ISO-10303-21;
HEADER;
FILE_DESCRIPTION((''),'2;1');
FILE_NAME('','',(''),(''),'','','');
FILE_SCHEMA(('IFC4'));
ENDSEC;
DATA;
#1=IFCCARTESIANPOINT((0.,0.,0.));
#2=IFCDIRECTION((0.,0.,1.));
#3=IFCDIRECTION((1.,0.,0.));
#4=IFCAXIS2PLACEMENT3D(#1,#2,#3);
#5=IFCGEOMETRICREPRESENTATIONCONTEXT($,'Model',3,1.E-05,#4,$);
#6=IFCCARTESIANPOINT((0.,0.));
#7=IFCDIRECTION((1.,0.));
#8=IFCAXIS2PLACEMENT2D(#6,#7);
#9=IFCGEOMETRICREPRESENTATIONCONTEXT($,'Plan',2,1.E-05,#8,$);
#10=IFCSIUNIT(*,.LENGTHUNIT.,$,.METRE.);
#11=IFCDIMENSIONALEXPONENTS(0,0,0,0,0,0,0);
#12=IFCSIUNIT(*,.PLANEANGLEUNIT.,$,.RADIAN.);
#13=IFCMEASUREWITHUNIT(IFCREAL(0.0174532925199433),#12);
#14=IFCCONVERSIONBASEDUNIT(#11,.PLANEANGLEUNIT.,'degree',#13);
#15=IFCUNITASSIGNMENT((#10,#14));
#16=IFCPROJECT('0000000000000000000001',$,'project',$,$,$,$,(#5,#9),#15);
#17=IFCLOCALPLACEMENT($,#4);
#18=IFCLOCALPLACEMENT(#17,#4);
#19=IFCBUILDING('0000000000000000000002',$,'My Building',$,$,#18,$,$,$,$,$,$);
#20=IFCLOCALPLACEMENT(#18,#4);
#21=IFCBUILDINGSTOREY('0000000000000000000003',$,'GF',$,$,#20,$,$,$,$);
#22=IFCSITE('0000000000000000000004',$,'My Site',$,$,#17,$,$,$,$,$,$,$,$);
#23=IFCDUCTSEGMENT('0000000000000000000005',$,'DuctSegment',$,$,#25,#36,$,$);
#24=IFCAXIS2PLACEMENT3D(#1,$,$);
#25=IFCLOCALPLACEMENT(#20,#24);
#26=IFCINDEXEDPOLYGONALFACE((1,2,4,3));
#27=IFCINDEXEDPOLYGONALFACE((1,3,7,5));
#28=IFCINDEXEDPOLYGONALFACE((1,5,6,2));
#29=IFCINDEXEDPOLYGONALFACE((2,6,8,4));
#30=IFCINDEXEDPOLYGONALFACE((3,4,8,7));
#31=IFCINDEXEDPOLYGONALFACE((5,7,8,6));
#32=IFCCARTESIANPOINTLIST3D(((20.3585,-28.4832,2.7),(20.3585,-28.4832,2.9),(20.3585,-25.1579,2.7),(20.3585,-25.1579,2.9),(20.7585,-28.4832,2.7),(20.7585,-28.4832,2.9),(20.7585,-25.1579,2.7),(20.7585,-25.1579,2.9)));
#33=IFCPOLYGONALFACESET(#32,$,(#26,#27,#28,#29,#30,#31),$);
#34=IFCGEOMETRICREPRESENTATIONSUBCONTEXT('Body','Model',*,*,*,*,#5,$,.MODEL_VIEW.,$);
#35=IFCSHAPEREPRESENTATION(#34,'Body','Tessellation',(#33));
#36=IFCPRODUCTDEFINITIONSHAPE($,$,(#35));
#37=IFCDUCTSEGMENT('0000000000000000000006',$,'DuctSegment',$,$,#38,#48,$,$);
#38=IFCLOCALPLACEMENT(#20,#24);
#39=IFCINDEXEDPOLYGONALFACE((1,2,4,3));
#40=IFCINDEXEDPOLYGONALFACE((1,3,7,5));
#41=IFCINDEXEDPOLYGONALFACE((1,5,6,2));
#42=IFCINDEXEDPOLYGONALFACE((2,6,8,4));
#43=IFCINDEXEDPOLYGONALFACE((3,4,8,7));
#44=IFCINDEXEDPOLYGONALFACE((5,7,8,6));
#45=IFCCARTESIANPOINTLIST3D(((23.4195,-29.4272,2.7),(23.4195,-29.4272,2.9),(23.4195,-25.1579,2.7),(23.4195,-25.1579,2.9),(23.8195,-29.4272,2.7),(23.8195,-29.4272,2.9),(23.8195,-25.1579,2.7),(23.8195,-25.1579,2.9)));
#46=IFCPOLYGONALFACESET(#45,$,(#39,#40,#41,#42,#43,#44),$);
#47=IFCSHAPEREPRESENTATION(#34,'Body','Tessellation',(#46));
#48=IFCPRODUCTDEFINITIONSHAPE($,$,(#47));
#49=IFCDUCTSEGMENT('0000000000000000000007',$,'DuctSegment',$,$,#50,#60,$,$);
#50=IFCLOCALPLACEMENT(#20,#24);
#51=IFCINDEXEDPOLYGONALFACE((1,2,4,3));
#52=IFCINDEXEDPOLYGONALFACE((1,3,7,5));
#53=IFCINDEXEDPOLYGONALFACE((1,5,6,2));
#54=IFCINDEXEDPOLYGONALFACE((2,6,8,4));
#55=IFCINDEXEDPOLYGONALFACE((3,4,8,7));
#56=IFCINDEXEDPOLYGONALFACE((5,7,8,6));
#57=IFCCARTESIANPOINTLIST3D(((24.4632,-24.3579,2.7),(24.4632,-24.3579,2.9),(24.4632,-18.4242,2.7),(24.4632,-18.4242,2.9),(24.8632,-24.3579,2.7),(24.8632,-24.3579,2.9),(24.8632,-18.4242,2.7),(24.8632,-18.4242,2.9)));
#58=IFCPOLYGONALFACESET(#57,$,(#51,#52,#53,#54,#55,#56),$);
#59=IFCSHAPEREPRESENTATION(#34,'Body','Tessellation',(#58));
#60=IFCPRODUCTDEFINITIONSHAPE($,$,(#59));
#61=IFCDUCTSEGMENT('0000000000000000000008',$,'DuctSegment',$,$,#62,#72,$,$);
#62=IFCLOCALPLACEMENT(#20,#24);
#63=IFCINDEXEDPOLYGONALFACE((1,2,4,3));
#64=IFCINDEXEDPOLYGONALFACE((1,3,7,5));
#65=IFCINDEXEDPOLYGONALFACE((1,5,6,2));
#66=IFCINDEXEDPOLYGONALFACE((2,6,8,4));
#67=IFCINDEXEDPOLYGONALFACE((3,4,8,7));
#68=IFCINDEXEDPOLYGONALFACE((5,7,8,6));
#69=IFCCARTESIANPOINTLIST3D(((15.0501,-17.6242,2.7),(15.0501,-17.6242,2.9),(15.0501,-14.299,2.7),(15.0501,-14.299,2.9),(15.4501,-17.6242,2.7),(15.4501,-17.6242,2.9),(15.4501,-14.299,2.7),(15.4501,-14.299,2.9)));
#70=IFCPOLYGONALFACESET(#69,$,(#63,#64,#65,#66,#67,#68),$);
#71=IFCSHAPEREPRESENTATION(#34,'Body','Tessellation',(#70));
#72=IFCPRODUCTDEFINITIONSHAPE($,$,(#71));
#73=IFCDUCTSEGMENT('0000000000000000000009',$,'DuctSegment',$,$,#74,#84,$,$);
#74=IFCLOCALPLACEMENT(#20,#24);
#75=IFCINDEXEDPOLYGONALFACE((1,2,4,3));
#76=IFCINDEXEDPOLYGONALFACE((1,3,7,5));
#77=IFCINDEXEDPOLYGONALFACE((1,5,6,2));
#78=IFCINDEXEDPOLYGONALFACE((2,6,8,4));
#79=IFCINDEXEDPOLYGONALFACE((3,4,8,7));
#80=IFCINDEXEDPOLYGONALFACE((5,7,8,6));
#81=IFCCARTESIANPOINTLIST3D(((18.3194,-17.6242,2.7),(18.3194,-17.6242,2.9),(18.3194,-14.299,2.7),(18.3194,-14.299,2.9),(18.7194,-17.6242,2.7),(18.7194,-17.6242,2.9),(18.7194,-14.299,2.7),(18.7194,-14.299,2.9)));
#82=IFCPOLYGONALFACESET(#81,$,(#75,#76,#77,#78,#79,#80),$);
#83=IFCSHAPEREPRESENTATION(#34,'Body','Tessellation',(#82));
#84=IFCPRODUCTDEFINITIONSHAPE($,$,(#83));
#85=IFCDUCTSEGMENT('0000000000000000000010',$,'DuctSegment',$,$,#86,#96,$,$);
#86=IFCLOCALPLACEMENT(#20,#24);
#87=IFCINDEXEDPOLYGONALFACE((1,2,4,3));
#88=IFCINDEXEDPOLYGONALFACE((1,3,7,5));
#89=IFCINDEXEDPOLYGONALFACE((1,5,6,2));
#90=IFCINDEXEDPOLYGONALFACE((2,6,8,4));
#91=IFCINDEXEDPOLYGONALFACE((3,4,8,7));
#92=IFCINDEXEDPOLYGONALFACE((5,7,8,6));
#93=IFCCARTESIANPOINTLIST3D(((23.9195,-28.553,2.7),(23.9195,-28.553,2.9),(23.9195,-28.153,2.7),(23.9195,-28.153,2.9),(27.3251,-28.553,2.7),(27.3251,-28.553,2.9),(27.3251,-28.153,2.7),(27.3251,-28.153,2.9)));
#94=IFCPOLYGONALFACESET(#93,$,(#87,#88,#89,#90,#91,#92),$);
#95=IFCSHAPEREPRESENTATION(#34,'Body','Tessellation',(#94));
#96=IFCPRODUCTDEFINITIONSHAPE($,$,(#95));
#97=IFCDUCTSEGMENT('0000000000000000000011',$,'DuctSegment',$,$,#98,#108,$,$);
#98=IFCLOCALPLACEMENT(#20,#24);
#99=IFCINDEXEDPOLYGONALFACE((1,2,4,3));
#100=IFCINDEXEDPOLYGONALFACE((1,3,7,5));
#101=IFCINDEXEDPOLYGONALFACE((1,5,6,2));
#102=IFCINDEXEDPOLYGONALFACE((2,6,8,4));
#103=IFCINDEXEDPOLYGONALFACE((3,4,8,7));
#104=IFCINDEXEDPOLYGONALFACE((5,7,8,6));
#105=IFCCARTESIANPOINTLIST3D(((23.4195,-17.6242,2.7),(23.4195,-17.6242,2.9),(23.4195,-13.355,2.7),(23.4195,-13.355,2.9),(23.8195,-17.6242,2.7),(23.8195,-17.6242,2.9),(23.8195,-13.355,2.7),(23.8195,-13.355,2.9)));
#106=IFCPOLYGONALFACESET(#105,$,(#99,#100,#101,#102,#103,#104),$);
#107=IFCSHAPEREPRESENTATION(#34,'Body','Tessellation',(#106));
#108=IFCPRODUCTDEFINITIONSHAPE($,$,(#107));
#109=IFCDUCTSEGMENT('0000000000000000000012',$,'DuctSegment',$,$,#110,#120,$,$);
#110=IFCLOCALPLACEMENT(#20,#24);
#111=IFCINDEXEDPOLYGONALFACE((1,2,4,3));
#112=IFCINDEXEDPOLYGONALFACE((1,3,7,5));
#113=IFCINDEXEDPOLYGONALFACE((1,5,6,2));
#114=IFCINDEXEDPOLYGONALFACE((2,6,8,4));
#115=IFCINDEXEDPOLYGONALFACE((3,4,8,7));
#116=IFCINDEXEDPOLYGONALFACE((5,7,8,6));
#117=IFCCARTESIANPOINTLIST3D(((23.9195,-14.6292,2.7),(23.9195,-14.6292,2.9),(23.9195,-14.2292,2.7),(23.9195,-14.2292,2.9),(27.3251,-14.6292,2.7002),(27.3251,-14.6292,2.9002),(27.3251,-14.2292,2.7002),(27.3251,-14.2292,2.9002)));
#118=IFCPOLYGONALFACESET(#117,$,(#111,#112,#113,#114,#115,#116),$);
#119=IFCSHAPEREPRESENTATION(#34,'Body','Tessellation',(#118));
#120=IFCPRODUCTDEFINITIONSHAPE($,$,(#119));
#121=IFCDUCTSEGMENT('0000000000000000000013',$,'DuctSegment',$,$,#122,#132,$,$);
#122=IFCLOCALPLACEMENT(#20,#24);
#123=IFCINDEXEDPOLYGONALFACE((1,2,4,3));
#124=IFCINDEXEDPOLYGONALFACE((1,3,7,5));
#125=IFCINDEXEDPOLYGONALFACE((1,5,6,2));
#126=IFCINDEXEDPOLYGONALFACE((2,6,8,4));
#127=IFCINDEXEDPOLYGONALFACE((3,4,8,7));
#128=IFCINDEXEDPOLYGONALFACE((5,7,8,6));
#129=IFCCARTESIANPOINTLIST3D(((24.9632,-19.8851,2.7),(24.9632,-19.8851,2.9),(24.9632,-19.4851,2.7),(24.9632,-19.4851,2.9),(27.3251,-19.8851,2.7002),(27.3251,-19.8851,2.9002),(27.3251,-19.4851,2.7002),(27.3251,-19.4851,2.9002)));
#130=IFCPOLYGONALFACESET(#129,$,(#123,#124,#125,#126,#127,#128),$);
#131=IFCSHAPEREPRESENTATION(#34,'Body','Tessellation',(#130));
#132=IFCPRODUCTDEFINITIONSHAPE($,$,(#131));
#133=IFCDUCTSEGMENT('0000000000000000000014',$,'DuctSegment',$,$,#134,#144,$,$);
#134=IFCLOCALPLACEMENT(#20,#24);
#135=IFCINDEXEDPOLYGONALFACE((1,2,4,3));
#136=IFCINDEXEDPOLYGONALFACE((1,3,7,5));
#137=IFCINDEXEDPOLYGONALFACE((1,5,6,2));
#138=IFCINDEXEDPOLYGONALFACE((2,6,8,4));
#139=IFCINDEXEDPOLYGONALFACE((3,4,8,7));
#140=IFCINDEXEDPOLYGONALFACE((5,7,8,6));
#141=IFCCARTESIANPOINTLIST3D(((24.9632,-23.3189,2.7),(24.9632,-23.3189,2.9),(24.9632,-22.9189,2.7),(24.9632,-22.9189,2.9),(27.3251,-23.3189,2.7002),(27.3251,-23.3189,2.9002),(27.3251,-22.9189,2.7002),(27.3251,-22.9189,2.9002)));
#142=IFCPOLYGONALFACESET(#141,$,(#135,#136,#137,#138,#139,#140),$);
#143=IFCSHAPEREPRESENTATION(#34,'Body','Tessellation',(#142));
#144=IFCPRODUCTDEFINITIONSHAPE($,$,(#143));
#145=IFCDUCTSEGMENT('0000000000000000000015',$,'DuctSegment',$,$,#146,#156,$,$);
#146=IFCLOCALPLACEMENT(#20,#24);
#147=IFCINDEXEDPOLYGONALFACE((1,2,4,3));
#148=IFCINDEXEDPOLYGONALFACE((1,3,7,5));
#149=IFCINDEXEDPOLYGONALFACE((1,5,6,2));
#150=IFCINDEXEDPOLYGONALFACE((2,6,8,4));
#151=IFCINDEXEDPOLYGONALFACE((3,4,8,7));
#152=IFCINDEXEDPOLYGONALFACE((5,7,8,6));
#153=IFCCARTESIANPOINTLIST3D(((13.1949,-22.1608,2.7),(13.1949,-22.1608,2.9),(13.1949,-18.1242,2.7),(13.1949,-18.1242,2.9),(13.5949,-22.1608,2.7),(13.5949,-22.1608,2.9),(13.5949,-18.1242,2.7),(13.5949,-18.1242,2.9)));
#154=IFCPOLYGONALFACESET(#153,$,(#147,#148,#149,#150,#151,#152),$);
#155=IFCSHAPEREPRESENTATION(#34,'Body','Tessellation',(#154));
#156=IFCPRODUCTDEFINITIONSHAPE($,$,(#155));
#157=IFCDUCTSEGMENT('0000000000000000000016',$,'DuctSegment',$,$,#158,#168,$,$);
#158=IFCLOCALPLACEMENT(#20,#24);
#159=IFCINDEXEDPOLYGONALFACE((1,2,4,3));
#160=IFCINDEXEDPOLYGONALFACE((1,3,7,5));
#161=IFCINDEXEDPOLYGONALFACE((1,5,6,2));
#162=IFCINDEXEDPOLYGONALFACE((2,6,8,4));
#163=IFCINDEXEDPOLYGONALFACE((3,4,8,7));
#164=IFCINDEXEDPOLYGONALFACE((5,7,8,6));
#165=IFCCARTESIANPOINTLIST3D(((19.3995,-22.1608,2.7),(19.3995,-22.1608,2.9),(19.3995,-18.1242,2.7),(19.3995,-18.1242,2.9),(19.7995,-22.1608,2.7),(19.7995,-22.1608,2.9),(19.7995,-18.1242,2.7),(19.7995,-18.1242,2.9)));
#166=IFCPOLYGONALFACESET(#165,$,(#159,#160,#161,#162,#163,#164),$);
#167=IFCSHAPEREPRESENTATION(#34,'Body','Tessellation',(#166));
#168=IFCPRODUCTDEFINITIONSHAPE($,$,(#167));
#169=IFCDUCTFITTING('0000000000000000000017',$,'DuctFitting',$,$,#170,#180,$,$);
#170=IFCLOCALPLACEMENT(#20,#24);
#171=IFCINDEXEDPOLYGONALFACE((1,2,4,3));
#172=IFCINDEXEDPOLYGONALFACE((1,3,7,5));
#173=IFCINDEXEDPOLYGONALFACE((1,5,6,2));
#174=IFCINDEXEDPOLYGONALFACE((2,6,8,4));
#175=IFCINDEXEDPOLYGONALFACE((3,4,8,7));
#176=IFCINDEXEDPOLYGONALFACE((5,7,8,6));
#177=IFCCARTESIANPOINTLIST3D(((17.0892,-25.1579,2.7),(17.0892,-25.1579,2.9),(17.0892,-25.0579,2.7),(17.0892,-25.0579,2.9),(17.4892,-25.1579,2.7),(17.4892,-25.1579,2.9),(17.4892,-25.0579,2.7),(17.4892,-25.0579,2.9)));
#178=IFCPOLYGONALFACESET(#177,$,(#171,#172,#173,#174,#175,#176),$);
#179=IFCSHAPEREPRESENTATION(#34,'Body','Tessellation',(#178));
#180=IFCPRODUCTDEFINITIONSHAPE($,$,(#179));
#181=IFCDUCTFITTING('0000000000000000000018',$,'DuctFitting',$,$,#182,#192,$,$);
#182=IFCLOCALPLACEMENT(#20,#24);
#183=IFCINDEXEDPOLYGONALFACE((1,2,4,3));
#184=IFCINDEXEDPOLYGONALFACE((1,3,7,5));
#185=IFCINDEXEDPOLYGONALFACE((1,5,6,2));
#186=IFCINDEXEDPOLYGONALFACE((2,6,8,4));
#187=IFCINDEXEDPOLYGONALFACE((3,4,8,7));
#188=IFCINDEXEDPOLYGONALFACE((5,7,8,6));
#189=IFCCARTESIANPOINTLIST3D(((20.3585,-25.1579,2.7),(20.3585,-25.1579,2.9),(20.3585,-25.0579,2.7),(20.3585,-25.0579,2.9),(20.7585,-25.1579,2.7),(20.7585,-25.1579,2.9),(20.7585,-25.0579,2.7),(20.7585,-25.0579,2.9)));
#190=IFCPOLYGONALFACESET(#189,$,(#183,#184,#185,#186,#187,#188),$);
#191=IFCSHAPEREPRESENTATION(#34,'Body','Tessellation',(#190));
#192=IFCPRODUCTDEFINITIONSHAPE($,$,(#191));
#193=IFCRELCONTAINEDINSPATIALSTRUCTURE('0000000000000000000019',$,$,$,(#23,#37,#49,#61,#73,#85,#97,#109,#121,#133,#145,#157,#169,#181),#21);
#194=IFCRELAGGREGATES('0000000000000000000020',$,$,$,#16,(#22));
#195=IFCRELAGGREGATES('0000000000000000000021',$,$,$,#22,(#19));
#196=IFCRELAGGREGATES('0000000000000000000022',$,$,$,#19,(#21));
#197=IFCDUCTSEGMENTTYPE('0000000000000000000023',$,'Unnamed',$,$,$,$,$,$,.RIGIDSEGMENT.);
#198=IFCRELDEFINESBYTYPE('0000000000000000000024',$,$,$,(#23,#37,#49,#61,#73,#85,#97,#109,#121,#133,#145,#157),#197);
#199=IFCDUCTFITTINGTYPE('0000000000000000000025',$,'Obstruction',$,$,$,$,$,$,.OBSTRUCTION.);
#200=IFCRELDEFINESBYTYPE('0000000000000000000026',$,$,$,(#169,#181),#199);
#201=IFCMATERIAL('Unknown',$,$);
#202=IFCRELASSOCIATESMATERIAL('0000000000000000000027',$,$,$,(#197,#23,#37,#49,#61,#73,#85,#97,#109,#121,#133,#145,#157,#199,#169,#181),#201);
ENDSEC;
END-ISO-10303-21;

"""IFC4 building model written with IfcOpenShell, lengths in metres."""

from ifc_helpers import new_model, entity, si_unit, converted_unit, frame, origin_with_axes, origin_2d_with_axis, place, context, subcontext, project, spatial, rectangle, extrude, material, material_profile, profile_set, profile_usage, type_object, element, save


model = new_model("IFC4")

# Units and contexts
model_context = context("Model", 3, precision=1e-05, world=origin_with_axes())
plan_context = context("Plan", 2, precision=1e-05, world=origin_2d_with_axis())
body_context_1 = subcontext(model_context, "Body", "Model", "MODEL_VIEW")
ifc_project = project(units=[si_unit("LENGTHUNIT", "METRE"), converted_unit("PLANEANGLEUNIT", "degree", entity("IfcReal", 0.0174532925199433), si_unit("PLANEANGLEUNIT", "RADIAN"), dimensions=[0, 0, 0, 0, 0, 0, 0])], contexts=[model_context, plan_context])

# Site, building, storey
site_placement = place(None, origin_with_axes())
site = spatial("IfcSite", under=ifc_project, at=site_placement, Name="My Site")
building_placement = place(site_placement, origin_with_axes())
building = spatial("IfcBuilding", under=site, at=building_placement, Name="My Building")
storey_placement = place(building_placement, origin_with_axes())
storey = spatial("IfcBuildingStorey", under=building, at=storey_placement, Name="GF")

# Shared definitions
ifc_material = material(Name="Unknown")

# Duct segments
ifc_material_profile_1 = material_profile(ifc_material, rectangle(XDim=0.4, YDim=0.2))
ifc_profile_set_1 = profile_set([ifc_material_profile_1])
duct_segment_type = type_object("IfcDuctSegmentType", Name="Unnamed", PredefinedType="RIGIDSEGMENT", material=ifc_profile_set_1)
ifc_profile_usage_1 = profile_usage(ifc_profile_set_1, cardinal=5)
duct_segment_1_placement = place(storey_placement, frame((20.5585, -25.1579, 2.8), z_axis=(0.0, -1.0, 0.0), x_axis=(1.0, 0.0, 0.0)))
element("IfcDuctSegment", 1, at=duct_segment_1_placement, inside=storey, type_object=duct_segment_type, material=ifc_profile_usage_1, Name="DuctSegment", context=body_context_1, shape_type="SweptSolid", body=[
    extrude(rectangle(XDim=0.4, YDim=0.2), origin_with_axes(), (0.0, 0.0, 1.0), 3.3252),
])
ifc_profile_usage_2 = profile_usage(ifc_profile_set_1, cardinal=5)
duct_segment_2_placement = place(storey_placement, frame((23.6195, -25.1579, 2.8), z_axis=(0.0, -1.0, 0.0), x_axis=(1.0, 0.0, 0.0)))
element("IfcDuctSegment", 2, at=duct_segment_2_placement, inside=storey, type_object=duct_segment_type, material=ifc_profile_usage_2, Name="DuctSegment", context=body_context_1, shape_type="SweptSolid", body=[
    extrude(rectangle(XDim=0.4, YDim=0.2), origin_with_axes(), (0.0, 0.0, 1.0), 4.2693),
])
ifc_profile_usage_3 = profile_usage(ifc_profile_set_1, cardinal=5)
duct_segment_3_placement = place(storey_placement, frame((24.6632, -18.4242, 2.8), z_axis=(0.0, -1.0, 0.0), x_axis=(1.0, 0.0, 0.0)))
element("IfcDuctSegment", 3, at=duct_segment_3_placement, inside=storey, type_object=duct_segment_type, material=ifc_profile_usage_3, Name="DuctSegment", context=body_context_1, shape_type="SweptSolid", body=[
    extrude(rectangle(XDim=0.4, YDim=0.2), origin_with_axes(), (0.0, 0.0, 1.0), 5.9337),
])
ifc_profile_usage_4 = profile_usage(ifc_profile_set_1, cardinal=5)
duct_segment_4_placement = place(storey_placement, frame((15.2501, -17.6242, 2.8), z_axis=(0.0, 1.0, 0.0), x_axis=(-1.0, 0.0, 0.0)))
element("IfcDuctSegment", 4, at=duct_segment_4_placement, inside=storey, type_object=duct_segment_type, material=ifc_profile_usage_4, Name="DuctSegment", context=body_context_1, shape_type="SweptSolid", body=[
    extrude(rectangle(XDim=0.4, YDim=0.2), origin_with_axes(), (0.0, 0.0, 1.0), 3.3252),
])
ifc_profile_usage_5 = profile_usage(ifc_profile_set_1, cardinal=5)
duct_segment_5_placement = place(storey_placement, frame((18.5194, -17.6242, 2.8), z_axis=(0.0, 1.0, 0.0), x_axis=(-1.0, 0.0, 0.0)))
element("IfcDuctSegment", 5, at=duct_segment_5_placement, inside=storey, type_object=duct_segment_type, material=ifc_profile_usage_5, Name="DuctSegment", context=body_context_1, shape_type="SweptSolid", body=[
    extrude(rectangle(XDim=0.4, YDim=0.2), origin_with_axes(), (0.0, 0.0, 1.0), 3.3252),
])
ifc_profile_usage_6 = profile_usage(ifc_profile_set_1, cardinal=5)
duct_segment_6_placement = place(storey_placement, frame((23.9195, -28.353, 2.8), z_axis=(1.0, 0.0, 0.0), x_axis=(0.0, 1.0, 0.0)))
element("IfcDuctSegment", 6, at=duct_segment_6_placement, inside=storey, type_object=duct_segment_type, material=ifc_profile_usage_6, Name="DuctSegment", context=body_context_1, shape_type="SweptSolid", body=[
    extrude(rectangle(XDim=0.4, YDim=0.2), origin_with_axes(), (0.0, 0.0, 1.0), 3.4056),
])
ifc_profile_usage_7 = profile_usage(ifc_profile_set_1, cardinal=5)
duct_segment_7_placement = place(storey_placement, frame((23.6195, -17.6242, 2.8), z_axis=(0.0, 1.0, 0.0), x_axis=(1.0, 0.0, -0.000004)))
element("IfcDuctSegment", 7, at=duct_segment_7_placement, inside=storey, type_object=duct_segment_type, material=ifc_profile_usage_7, Name="DuctSegment", context=body_context_1, shape_type="SweptSolid", body=[
    extrude(rectangle(XDim=0.4, YDim=0.2), origin_with_axes(), (0.0, 0.0, 1.0), 4.2693),
])
ifc_profile_usage_8 = profile_usage(ifc_profile_set_1, cardinal=5)
duct_segment_8_placement = place(storey_placement, frame((23.9195, -14.4292, 2.8), z_axis=(1.0, 0.0, 0.00005), x_axis=(0.0, -1.0, 0.0)))
element("IfcDuctSegment", 8, at=duct_segment_8_placement, inside=storey, type_object=duct_segment_type, material=ifc_profile_usage_8, Name="DuctSegment", context=body_context_1, shape_type="SweptSolid", body=[
    extrude(rectangle(XDim=0.4, YDim=0.2), origin_with_axes(), (0.0, 0.0, 1.0), 3.4056),
])
ifc_profile_usage_9 = profile_usage(ifc_profile_set_1, cardinal=5)
duct_segment_9_placement = place(storey_placement, frame((24.9632, -19.6851, 2.8), z_axis=(1.0, -0.000001, 0.000072), x_axis=(0.000001, 1.0, 0.0)))
element("IfcDuctSegment", 9, at=duct_segment_9_placement, inside=storey, type_object=duct_segment_type, material=ifc_profile_usage_9, Name="DuctSegment", context=body_context_1, shape_type="SweptSolid", body=[
    extrude(rectangle(XDim=0.4, YDim=0.2), origin_with_axes(), (0.0, 0.0, 1.0), 2.3619),
])
ifc_profile_usage_10 = profile_usage(ifc_profile_set_1, cardinal=5)
duct_segment_10_placement = place(storey_placement, frame((24.9632, -23.1189, 2.8), z_axis=(1.0, -0.000001, 0.000072), x_axis=(0.000001, 1.0, 0.0)))
element("IfcDuctSegment", 10, at=duct_segment_10_placement, inside=storey, type_object=duct_segment_type, material=ifc_profile_usage_10, Name="DuctSegment", context=body_context_1, shape_type="SweptSolid", body=[
    extrude(rectangle(XDim=0.4, YDim=0.2), origin_with_axes(), (0.0, 0.0, 1.0), 2.362),
])
ifc_profile_usage_11 = profile_usage(ifc_profile_set_1, cardinal=5)
duct_segment_11_placement = place(storey_placement, frame((13.3949, -18.1242, 2.8), z_axis=(0.0, -1.0, 0.0), x_axis=(1.0, 0.0, 0.0)))
element("IfcDuctSegment", 11, at=duct_segment_11_placement, inside=storey, type_object=duct_segment_type, material=ifc_profile_usage_11, Name="DuctSegment", context=body_context_1, shape_type="SweptSolid", body=[
    extrude(rectangle(XDim=0.4, YDim=0.2), origin_with_axes(), (0.0, 0.0, 1.0), 4.0366),
])
ifc_profile_usage_12 = profile_usage(ifc_profile_set_1, cardinal=5)
duct_segment_12_placement = place(storey_placement, frame((19.5995, -18.1242, 2.8), z_axis=(0.0, -1.0, 0.0), x_axis=(1.0, 0.0, 0.0)))
element("IfcDuctSegment", 12, at=duct_segment_12_placement, inside=storey, type_object=duct_segment_type, material=ifc_profile_usage_12, Name="DuctSegment", context=body_context_1, shape_type="SweptSolid", body=[
    extrude(rectangle(XDim=0.4, YDim=0.2), origin_with_axes(), (0.0, 0.0, 1.0), 4.0366),
])

# Duct fittings
ifc_material_profile_2 = material_profile(ifc_material, rectangle(XDim=0.4, YDim=0.2))
ifc_profile_set_2 = profile_set([ifc_material_profile_2])
ifc_profile_usage_13 = profile_usage(ifc_profile_set_2, cardinal=5)
duct_fitting_type_1 = type_object("IfcDuctFittingType", Name="Obstruction", PredefinedType="OBSTRUCTION", material=ifc_profile_set_2)
duct_fitting_1_placement = place(storey_placement, frame((17.2892, -25.0579, 2.8), z_axis=(0.0, -1.0, 0.0), x_axis=(1.0, 0.0, 0.0)))
element("IfcDuctFitting", 13, at=duct_fitting_1_placement, inside=storey, type_object=duct_fitting_type_1, material=ifc_profile_usage_13, Name="DuctFitting", context=body_context_1, shape_type="SweptSolid", body=[
    extrude(rectangle(XDim=0.4, YDim=0.2), origin_with_axes(), (0.0, 0.0, 1.0), 0.1),
])
ifc_profile_usage_14 = profile_usage(ifc_profile_set_2, cardinal=5)
duct_fitting_2_placement = place(storey_placement, frame((20.5585, -25.0579, 2.8), z_axis=(0.0, -1.0, 0.0), x_axis=(1.0, 0.0, 0.0)))
element("IfcDuctFitting", 14, at=duct_fitting_2_placement, inside=storey, type_object=duct_fitting_type_1, material=ifc_profile_usage_14, Name="DuctFitting", context=body_context_1, shape_type="SweptSolid", body=[
    extrude(rectangle(XDim=0.4, YDim=0.2), origin_with_axes(), (0.0, 0.0, 1.0), 0.1),
])

save(model, "model.ifc")
